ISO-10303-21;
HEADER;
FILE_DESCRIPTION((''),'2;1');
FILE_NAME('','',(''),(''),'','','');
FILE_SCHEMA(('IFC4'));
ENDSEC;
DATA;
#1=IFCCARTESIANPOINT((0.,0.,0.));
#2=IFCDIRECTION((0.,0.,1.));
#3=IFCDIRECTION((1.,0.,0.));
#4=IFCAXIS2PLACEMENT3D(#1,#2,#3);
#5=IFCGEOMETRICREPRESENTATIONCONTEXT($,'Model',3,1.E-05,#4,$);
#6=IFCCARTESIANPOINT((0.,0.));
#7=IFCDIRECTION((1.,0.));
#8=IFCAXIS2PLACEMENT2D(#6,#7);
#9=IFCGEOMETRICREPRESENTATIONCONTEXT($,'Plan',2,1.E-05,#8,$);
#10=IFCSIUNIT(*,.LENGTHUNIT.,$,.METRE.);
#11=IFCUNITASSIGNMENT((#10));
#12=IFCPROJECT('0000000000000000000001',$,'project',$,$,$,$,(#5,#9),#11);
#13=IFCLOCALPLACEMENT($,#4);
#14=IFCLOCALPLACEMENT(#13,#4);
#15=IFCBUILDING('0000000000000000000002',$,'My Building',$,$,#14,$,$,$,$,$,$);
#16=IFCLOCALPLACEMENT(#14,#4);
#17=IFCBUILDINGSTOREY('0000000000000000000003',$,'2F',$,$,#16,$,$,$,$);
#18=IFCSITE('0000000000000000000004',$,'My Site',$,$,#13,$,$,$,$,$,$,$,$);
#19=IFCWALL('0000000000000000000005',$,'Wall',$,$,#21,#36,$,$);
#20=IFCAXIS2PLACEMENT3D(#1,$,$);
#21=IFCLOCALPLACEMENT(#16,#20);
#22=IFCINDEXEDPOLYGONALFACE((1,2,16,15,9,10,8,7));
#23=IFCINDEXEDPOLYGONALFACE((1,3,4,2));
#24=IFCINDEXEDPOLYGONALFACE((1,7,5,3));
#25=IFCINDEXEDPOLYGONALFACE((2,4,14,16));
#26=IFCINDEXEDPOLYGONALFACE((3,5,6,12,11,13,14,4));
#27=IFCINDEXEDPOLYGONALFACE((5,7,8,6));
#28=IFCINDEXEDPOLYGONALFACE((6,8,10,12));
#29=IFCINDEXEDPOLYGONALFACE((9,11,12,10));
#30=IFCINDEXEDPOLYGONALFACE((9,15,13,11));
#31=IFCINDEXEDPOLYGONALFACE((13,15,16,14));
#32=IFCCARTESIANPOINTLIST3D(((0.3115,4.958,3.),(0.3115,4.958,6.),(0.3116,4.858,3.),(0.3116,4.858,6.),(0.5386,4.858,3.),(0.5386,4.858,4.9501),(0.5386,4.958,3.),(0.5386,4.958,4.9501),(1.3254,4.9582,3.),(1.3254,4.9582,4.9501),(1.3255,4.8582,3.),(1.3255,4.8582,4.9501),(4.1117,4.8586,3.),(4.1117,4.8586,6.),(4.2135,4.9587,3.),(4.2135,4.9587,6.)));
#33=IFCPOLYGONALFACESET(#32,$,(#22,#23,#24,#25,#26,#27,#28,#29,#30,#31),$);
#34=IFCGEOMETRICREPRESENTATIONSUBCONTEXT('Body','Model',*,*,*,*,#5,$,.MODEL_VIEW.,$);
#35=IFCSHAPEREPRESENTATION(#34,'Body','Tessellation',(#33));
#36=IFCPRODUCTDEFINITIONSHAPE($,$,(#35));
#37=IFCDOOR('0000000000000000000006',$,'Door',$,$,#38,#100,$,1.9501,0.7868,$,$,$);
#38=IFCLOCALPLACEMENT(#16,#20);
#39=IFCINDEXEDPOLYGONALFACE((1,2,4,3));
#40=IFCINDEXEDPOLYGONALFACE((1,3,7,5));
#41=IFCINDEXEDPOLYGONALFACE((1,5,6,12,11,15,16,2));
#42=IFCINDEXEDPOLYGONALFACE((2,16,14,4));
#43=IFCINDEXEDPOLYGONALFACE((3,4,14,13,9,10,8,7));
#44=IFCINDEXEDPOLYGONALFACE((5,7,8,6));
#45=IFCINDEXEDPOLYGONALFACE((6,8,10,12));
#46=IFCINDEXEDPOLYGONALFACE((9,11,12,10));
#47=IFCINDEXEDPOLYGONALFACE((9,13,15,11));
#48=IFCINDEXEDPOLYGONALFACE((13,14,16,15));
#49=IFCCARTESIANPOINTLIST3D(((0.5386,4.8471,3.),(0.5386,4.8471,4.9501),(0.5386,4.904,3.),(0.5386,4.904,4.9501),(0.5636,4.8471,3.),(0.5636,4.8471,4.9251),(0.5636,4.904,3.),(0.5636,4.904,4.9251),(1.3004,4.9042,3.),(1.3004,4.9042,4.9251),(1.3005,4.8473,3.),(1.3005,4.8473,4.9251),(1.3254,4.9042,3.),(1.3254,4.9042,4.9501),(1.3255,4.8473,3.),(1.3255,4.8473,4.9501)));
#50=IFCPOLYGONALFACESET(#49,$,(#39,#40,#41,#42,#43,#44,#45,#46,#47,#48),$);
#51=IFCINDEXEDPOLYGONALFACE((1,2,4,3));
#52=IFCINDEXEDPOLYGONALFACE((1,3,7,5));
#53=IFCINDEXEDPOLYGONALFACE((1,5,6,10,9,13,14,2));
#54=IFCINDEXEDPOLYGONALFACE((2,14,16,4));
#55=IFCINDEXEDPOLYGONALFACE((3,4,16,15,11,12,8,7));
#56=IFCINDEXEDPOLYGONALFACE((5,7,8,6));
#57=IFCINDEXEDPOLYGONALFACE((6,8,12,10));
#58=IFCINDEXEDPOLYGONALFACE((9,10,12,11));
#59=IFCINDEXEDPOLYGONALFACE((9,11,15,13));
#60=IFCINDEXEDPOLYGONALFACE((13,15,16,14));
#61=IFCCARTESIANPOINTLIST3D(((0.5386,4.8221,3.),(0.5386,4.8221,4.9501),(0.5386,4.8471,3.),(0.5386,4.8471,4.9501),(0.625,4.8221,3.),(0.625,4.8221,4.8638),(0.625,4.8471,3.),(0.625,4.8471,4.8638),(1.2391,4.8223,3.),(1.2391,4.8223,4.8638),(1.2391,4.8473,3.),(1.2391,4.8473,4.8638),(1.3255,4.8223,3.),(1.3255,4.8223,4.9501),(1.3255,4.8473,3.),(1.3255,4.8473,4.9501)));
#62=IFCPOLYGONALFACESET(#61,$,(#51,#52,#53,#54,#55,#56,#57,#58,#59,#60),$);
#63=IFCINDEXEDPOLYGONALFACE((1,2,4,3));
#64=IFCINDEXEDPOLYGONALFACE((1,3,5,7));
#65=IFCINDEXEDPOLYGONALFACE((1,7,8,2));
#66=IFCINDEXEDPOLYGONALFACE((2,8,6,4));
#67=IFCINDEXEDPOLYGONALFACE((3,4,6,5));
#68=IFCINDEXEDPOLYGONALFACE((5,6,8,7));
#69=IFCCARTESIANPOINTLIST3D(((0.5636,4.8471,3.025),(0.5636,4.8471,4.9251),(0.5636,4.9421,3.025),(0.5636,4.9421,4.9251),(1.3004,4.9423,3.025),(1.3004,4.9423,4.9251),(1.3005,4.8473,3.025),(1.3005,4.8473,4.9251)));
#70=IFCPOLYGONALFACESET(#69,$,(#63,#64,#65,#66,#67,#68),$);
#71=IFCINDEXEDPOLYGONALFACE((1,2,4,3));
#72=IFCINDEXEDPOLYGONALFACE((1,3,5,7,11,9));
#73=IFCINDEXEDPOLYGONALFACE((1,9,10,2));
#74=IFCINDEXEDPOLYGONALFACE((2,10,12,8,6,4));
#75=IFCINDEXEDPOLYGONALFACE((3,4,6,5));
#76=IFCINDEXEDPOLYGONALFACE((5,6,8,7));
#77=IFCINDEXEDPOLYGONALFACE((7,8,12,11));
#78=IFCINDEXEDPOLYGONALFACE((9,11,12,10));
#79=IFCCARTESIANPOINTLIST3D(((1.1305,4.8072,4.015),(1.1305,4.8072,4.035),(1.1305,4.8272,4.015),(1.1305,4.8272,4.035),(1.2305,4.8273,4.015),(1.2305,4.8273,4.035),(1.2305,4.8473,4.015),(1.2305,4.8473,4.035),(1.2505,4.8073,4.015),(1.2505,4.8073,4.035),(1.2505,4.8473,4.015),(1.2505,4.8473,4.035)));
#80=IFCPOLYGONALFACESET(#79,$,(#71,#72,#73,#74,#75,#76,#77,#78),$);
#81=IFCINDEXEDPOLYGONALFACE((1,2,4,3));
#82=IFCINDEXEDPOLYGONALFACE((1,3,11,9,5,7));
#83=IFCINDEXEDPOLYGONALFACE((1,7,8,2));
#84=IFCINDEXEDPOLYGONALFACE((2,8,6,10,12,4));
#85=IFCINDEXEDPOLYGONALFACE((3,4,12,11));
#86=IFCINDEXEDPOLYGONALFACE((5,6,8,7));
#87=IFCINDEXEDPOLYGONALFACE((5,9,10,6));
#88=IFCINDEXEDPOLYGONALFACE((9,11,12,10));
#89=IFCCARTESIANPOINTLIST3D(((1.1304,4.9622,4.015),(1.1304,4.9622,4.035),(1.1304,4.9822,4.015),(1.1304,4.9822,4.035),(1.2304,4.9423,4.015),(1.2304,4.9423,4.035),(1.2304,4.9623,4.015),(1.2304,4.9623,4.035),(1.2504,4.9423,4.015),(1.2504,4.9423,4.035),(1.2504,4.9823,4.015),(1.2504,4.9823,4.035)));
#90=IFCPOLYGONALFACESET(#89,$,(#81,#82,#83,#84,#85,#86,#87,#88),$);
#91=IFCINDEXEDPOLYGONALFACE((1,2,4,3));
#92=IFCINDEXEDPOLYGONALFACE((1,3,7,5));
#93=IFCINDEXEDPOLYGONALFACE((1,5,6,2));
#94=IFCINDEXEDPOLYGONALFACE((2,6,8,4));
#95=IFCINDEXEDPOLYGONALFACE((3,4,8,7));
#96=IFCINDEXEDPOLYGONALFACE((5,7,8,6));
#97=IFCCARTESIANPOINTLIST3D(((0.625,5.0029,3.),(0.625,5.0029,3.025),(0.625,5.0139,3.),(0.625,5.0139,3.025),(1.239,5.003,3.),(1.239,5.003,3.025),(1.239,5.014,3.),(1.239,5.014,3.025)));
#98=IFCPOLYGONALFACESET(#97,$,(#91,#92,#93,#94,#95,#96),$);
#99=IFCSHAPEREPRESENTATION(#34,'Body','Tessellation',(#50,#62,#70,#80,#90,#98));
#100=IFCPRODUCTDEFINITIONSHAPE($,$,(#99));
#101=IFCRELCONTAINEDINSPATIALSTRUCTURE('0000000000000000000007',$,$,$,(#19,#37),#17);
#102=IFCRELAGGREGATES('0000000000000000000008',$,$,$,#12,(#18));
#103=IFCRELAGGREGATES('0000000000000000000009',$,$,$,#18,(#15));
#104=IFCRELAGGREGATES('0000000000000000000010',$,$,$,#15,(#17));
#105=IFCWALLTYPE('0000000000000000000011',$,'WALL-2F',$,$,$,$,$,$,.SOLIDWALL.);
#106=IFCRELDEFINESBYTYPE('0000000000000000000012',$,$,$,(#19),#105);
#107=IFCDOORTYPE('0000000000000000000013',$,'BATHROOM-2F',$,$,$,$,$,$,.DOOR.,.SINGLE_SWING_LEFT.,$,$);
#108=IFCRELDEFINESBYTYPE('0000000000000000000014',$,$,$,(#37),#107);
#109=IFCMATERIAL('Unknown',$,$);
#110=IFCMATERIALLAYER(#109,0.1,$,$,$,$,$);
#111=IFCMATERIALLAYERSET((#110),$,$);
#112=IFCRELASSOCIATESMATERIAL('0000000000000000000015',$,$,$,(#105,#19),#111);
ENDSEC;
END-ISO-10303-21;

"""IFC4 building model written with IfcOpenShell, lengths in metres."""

from ifc_helpers import new_model, entity, si_unit, frame, origin_with_axes, origin_2d_with_axis, place, context, subcontext, project, spatial, line, indexed_curve, outline, extrude, shape, source, transform, mapped, material, layer, layer_set, layer_usage, type_object, type_shapes, element, fill, save


model = new_model("IFC4")

# Units and contexts
model_context = context("Model", 3, precision=1e-05, world=origin_with_axes())
plan_context = context("Plan", 2, precision=1e-05, world=origin_2d_with_axis())
body_context_1 = subcontext(model_context, "Body", "Model", "MODEL_VIEW")
body_context_2 = subcontext(plan_context, "Body", "Plan", "PLAN_VIEW")
ifc_project = project(units=[si_unit("LENGTHUNIT", "METRE")], contexts=[model_context, plan_context])

# Site, building, storey
site_placement = place(None, origin_with_axes())
site = spatial("IfcSite", under=ifc_project, at=site_placement, Name="My Site")
building_placement = place(site_placement, origin_with_axes())
building = spatial("IfcBuilding", under=site, at=building_placement, Name="My Building")
storey_placement = place(building_placement, origin_with_axes())
storey = spatial("IfcBuildingStorey", under=building, at=storey_placement, Name="2F")

# Shared definitions
ifc_material = material(Name="Unknown")

# Shared definitions
ifc_layer_1 = layer(ifc_material, 0.1)
ifc_layer_set_1 = layer_set([ifc_layer_1])
wall_type_1 = type_object("IfcWallType", Name="WALL-2F", PredefinedType="SOLIDWALL", material=ifc_layer_set_1)

# Wall, opening, door
ifc_layer_usage_1 = layer_usage(ifc_layer_set_1, "AXIS2", "POSITIVE", 0.0)
wall_1_placement = place(storey_placement, frame((4.2135, 4.9587, 3.0), z_axis=(0.0, 0.0, 1.0), x_axis=(-1.0, -0.000176, 0.0)))
wall_1 = element("IfcWall", 1, at=wall_1_placement, inside=storey, type_object=wall_type_1, material=ifc_layer_usage_1, Name="Wall", context=body_context_1, shape_type="SweptSolid", body=[
    extrude(outline(indexed_curve([(0.0, 0.0), (0.1018, 0.1), (3.9019, 0.1), (3.9019, 0.0)], segments=[line(1, 2, 3, 4, 1)])), origin_with_axes(), (0.0, 0.0, 1.0), 3.0),
])
shared_shape_1 = source(origin_with_axes(), body_context_1, "Body", "SweptSolid", [
    extrude(outline(indexed_curve([(0.0, 0.0), (0.7868, 0.0), (0.7868, 1.9501), (0.0, 1.9501)], segments=[line(1, 2, 3, 4, 1)])), frame((0.0, -0.6, 0.0), z_axis=(0.0, -1.0, 0.0), x_axis=(1.0, 0.0, 0.0)), (0.0, 0.0, -1.0), 1.2),
])
opening_1_placement = place(wall_1_placement, frame((3.6749, 0.1, 0.0), z_axis=(0.0, 0.0, 1.0), x_axis=(-1.0, 0.0, 0.0)))
opening_1 = element("IfcOpeningElement", 2, at=opening_1_placement, cuts=wall_1, PredefinedType="OPENING", context=body_context_1, shape_type="MappedRepresentation", body=[
    mapped(shared_shape_1, transform((0.0, 0.0, 0.0), x_axis=(1.0, 0.0, 0.0), y_axis=(0.0, 1.0, 0.0), z_axis=(0.0, 0.0, 1.0), scale=1.0)),
])
door_type_1 = type_object("IfcDoorType", Name="BATHROOM-2F", OperationType="SINGLE_SWING_LEFT", PredefinedType="DOOR")
shared_shape_2 = source(origin_with_axes(), body_context_1, "Body", "SweptSolid", [
    extrude(outline(indexed_curve([(0.0, 0.0), (0.0, 1.9501), (0.7868, 1.9501), (0.7868, 0.0), (0.7618, 0.0), (0.7618, 1.9251), (0.025, 1.9251), (0.025, 0.0)], segments=[line(1, 2, 3, 4, 5, 6, 7, 8, 1)])), frame((0.0, 0.0093, 0.0), z_axis=(0.0, -1.0, 0.0), x_axis=(1.0, 0.0, 0.0)), (0.0, 0.0, -1.0), 0.0569),
    extrude(outline(indexed_curve([(0.0, 0.0), (0.0, 1.9501), (0.7868, 1.9501), (0.7868, 0.0), (0.7005, 0.0), (0.7005, 1.8638), (0.0864, 1.8638), (0.0864, 0.0)], segments=[line(1, 2, 3, 4, 5, 6, 7, 8, 1)])), frame((0.0, -0.0157, 0.0), z_axis=(0.0, -1.0, 0.0), x_axis=(1.0, 0.0, 0.0)), (0.0, 0.0, -1.0), 0.025),
    extrude(outline(indexed_curve([(0.0, 0.0), (0.7368, 0.0), (0.7368, 0.095), (0.0, 0.095)], segments=[line(1, 2, 3, 4, 1)])), frame((0.025, 0.0093, 0.025), z_axis=(0.0, 0.0, 1.0), x_axis=(1.0, 0.0, 0.0)), (0.0, 0.0, 1.0), 1.9001),
    extrude(outline(indexed_curve([(0.0, 0.0), (0.0, -0.04), (-0.12, -0.04), (-0.12, -0.02), (-0.02, -0.02), (-0.02, 0.0)], segments=[line(1, 2, 3, 4, 5, 6, 1)])), frame((0.7118, 0.0093, 1.015), z_axis=(0.0, 0.0, 1.0), x_axis=(1.0, 0.0, 0.0)), (0.0, 0.0, 1.0), 0.02),
    extrude(outline(indexed_curve([(0.0, 0.0), (0.0, 0.04), (-0.12, 0.04), (-0.12, 0.02), (-0.02, 0.02), (-0.02, 0.0)], segments=[line(1, 2, 3, 4, 5, 6, 1)])), frame((0.7118, 0.1043, 1.015), z_axis=(0.0, 0.0, 1.0), x_axis=(1.0, 0.0, 0.0)), (0.0, 0.0, 1.0), 0.02),
    extrude(outline(indexed_curve([(0.0, 0.0), (0.6141, 0.0), (0.6141, 0.011), (0.0, 0.011)], segments=[line(1, 2, 3, 4, 1)])), frame((0.0864, 0.165, 0.0), z_axis=(0.0, 0.0, 1.0), x_axis=(1.0, 0.0, 0.0)), (0.0, 0.0, 1.0), 0.025),
])
shared_shape_3 = source(origin_with_axes(), body_context_2, "Body", "Curve2D", [
    entity("IfcIndexedPolyCurve", entity("IfcCartesianPointList2D", [[0.0, -0.0157], [0.0, 0.0662], [0.025, 0.0662], [0.025, 0.0093], [0.0864, 0.0093], [0.0864, -0.0157]]), [entity("IfcLineIndex", [1, 2, 3, 4, 5, 6, 1])]),
    entity("IfcIndexedPolyCurve", entity("IfcCartesianPointList2D", [[0.7868, -0.0157], [0.7868, 0.0662], [0.7618, 0.0662], [0.7618, 0.0093], [0.7005, 0.0093], [0.7005, -0.0157]]), [entity("IfcLineIndex", [1, 2, 3, 4, 5, 6, 1])]),
    entity("IfcTrimmedCurve", entity("IfcEllipse", entity("IfcAxis2Placement2D", entity("IfcCartesianPoint", [0.12, 0.0662]), entity("IfcDirection", [1.0, 0.0])), 0.6418, 0.7368), [entity("IfcCartesianPoint", [0.7618, 0.0662])], [entity("IfcCartesianPoint", [0.12, 0.803])], True, "CARTESIAN"),
    entity("IfcIndexedPolyCurve", entity("IfcCartesianPointList2D", [[0.025, 0.0662], [0.12, 0.0662], [0.12, 0.803], [0.025, 0.803]]), [entity("IfcLineIndex", [1, 2, 3, 4, 1])]),
])
type_shapes(door_type_1, [shared_shape_2, shared_shape_3])
door_1_placement = place(opening_1_placement, frame((0.0, -0.0202, 0.0), z_axis=(0.0, 0.0, 1.0), x_axis=(1.0, 0.0, 0.0)))
door_1 = element("IfcDoor", 3, at=door_1_placement, inside=storey, type_object=door_type_1, Name="Door", OverallHeight=1.9501, OverallWidth=0.7868, shapes=[
    shape(body_context_1, "Body", "MappedRepresentation", [mapped(shared_shape_2, transform((0.0, 0.0, 0.0), x_axis=(1.0, 0.0, 0.0), y_axis=(0.0, 1.0, 0.0), z_axis=(0.0, 0.0, 1.0), scale=1.0))]),
    shape(body_context_2, "Body", "MappedRepresentation", [mapped(shared_shape_3, transform((0.0, 0.0, 0.0), x_axis=(1.0, 0.0, 0.0), y_axis=(0.0, 1.0, 0.0), z_axis=(0.0, 0.0, 1.0), scale=1.0))]),
])
fill(opening_1, door_1)

save(model, "model.ifc")
